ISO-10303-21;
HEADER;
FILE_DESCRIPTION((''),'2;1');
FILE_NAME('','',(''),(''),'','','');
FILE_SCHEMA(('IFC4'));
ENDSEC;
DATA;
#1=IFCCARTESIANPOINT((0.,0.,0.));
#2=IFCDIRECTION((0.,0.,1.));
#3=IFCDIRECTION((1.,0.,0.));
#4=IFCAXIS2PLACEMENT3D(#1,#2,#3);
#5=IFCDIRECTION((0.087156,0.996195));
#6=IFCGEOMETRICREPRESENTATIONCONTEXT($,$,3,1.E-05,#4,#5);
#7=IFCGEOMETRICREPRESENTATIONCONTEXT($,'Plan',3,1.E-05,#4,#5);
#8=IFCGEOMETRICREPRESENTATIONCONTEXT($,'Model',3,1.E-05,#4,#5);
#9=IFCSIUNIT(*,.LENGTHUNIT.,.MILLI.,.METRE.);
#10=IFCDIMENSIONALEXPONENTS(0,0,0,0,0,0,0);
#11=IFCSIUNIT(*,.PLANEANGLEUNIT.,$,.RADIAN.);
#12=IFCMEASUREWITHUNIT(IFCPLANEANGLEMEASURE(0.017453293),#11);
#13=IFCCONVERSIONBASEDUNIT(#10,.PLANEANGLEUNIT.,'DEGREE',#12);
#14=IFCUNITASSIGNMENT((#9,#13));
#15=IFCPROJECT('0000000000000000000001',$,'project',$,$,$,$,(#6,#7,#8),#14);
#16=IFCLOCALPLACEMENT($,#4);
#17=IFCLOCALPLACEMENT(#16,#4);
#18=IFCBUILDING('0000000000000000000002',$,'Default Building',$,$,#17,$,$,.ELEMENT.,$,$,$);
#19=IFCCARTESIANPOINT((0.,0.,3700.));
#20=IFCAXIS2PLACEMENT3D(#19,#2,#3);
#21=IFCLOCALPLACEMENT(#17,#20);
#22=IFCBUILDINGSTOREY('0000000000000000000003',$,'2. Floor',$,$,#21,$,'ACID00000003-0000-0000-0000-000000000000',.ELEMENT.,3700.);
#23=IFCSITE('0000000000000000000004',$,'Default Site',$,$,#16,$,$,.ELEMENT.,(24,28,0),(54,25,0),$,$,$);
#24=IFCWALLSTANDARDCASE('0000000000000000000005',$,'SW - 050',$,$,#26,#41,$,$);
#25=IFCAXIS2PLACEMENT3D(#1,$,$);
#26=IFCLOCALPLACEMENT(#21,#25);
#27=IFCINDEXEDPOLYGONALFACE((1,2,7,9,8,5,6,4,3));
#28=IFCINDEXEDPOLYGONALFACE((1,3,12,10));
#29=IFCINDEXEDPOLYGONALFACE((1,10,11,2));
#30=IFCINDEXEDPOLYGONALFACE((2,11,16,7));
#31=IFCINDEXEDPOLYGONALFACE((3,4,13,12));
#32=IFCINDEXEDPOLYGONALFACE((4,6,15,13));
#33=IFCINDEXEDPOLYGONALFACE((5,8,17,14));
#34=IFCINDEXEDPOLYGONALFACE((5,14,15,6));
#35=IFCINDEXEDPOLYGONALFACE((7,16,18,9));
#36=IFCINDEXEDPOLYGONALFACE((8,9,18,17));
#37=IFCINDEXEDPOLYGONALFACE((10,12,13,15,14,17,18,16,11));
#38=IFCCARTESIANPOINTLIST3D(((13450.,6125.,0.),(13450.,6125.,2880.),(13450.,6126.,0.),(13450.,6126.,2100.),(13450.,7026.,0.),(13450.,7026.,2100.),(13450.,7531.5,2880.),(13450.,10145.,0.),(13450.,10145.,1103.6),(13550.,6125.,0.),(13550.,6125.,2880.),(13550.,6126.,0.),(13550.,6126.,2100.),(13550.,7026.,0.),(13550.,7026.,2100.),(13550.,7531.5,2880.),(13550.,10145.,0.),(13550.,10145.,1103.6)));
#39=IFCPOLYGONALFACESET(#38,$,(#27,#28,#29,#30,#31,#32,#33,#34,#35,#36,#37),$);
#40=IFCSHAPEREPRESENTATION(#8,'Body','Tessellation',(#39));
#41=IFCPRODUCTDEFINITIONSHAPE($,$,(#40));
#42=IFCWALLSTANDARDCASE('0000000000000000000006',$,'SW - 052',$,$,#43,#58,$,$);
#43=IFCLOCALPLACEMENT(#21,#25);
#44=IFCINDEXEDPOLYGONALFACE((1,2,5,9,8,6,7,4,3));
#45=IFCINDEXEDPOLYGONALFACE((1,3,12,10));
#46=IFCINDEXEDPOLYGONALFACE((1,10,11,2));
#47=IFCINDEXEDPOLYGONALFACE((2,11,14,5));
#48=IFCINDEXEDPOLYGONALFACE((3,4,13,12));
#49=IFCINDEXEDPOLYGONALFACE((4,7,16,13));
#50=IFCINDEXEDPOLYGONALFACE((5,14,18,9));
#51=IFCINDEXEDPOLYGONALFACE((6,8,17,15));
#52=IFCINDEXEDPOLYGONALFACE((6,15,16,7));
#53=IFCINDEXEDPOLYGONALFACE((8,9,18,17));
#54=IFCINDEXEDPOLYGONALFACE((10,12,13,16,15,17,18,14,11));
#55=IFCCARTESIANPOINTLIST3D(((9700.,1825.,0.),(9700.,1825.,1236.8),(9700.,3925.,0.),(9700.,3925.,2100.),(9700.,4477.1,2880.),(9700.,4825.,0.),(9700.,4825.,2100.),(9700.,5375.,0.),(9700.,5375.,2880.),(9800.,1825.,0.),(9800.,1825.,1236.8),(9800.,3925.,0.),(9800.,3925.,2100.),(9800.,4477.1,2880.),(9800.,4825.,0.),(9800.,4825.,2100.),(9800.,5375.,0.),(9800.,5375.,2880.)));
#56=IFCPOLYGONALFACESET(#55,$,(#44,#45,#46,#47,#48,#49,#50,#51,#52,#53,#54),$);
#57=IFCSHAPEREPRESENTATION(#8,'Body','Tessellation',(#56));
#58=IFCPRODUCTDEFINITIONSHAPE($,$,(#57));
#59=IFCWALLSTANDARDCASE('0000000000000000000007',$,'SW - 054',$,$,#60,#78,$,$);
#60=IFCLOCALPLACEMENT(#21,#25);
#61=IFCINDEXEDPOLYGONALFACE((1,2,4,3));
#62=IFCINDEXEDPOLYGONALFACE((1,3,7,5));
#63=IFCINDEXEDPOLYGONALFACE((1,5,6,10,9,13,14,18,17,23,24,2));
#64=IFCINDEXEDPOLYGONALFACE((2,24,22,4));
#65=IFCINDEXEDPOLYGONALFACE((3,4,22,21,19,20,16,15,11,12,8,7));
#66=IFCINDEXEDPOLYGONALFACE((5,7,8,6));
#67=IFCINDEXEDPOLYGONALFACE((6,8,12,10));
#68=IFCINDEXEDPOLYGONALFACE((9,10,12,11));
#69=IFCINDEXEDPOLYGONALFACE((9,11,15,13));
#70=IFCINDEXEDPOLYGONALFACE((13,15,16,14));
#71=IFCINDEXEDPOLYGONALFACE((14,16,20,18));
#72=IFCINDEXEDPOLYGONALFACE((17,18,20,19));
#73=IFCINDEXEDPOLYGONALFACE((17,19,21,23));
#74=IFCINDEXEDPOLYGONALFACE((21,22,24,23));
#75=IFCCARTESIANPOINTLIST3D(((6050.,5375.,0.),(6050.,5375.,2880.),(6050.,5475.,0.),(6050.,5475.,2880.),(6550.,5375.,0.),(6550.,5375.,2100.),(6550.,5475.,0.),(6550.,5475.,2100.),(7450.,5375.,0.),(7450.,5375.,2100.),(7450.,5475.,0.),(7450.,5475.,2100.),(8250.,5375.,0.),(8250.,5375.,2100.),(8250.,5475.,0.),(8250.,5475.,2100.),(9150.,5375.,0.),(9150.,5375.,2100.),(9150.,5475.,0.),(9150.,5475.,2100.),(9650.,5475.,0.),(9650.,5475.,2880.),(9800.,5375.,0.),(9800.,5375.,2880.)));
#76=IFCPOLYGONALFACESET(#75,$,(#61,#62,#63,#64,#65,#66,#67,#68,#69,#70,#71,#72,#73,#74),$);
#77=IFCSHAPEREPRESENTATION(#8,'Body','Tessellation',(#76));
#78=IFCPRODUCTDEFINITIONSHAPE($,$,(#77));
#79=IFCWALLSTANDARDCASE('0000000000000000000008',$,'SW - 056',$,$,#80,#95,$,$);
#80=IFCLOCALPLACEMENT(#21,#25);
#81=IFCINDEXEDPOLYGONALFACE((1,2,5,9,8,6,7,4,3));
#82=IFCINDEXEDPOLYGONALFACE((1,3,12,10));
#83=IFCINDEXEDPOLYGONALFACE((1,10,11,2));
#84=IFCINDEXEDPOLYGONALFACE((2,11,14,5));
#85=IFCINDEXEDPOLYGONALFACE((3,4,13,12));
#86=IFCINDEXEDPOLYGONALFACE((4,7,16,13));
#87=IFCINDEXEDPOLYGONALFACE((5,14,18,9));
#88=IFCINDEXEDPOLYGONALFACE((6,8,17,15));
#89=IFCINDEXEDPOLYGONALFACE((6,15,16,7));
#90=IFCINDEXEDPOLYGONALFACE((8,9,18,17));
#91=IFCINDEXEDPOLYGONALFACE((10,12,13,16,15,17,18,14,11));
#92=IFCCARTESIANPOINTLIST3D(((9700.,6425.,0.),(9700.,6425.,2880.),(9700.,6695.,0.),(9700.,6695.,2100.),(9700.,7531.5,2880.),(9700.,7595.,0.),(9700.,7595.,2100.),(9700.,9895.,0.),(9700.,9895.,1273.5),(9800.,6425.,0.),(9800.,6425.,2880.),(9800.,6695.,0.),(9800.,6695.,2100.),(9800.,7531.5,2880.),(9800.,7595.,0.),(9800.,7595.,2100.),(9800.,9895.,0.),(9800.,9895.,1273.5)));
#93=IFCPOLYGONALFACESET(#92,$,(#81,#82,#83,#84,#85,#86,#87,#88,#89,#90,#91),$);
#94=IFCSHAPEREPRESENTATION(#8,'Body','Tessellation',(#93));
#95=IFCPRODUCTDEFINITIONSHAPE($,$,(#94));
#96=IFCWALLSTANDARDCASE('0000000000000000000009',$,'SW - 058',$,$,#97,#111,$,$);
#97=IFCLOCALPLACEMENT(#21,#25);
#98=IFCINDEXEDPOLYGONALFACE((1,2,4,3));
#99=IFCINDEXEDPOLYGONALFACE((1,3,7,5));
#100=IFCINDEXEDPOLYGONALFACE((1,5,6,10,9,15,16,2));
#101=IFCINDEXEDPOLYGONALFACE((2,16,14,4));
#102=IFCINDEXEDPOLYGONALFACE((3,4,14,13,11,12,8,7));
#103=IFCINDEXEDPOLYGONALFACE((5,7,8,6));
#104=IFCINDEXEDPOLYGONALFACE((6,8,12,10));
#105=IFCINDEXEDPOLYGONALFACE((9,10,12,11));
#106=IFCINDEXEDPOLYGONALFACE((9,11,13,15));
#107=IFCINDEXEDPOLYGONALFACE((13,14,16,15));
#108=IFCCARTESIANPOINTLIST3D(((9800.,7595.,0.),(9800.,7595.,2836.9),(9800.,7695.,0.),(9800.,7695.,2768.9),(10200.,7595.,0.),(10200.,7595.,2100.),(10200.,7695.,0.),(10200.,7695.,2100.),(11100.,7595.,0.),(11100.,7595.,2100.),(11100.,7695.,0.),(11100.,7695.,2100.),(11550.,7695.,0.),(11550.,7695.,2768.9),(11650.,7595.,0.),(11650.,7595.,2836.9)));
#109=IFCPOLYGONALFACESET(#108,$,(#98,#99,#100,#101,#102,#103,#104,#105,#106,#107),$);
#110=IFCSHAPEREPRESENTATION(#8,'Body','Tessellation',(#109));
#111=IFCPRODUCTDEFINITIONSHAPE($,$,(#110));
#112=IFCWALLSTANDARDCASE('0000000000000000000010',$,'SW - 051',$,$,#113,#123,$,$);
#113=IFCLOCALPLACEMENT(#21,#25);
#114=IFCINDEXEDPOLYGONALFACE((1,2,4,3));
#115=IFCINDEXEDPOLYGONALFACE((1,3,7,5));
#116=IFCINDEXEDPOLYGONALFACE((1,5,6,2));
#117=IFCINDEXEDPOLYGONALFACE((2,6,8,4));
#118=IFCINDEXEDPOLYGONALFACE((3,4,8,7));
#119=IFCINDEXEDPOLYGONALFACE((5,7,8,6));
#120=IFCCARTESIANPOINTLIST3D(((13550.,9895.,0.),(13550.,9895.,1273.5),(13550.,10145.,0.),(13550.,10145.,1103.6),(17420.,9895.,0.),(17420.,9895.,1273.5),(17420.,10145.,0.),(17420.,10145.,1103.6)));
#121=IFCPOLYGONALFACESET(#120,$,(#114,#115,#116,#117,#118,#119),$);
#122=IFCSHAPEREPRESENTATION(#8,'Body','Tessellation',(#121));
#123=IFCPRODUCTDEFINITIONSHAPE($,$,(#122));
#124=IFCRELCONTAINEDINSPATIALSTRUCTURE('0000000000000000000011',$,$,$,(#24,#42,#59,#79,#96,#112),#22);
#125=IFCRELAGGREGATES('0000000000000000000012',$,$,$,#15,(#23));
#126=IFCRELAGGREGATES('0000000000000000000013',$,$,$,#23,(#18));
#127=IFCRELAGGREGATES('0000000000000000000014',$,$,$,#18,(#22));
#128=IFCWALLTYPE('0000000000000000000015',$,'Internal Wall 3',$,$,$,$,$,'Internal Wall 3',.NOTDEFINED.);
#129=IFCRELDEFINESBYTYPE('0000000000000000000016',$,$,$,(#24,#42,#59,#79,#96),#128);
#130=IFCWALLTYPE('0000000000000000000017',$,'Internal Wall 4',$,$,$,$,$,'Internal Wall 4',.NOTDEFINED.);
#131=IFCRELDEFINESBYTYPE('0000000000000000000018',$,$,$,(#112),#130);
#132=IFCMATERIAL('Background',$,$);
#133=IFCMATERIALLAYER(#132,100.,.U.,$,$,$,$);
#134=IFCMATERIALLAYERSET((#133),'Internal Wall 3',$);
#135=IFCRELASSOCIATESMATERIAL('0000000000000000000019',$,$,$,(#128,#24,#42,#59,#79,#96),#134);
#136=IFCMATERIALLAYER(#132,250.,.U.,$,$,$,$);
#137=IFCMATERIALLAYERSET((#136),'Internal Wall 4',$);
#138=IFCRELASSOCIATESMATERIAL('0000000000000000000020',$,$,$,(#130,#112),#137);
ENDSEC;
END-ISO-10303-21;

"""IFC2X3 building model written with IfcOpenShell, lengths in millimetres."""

from ifc_helpers import new_model, entity, si_unit, converted_unit, direction, frame, frame_2d, origin_with_axes, place, context, project, spatial, polyline, rectangle, outline, extrude, clip, halfspace, material, layer, layer_set, layer_usage, type_object, element, save


model = new_model("IFC2X3")

# Units and contexts
context_of_model = context(None, 3, precision=1e-05, world=origin_with_axes(), true_north=direction((0.087156, 0.996195)))
plan_context = context("Plan", 3, precision=1e-05, world=origin_with_axes(), true_north=direction((0.087156, 0.996195)))
model_context = context("Model", 3, precision=1e-05, world=origin_with_axes(), true_north=direction((0.087156, 0.996195)))
ifc_project = project(units=[si_unit("LENGTHUNIT", "METRE", prefix="MILLI"), converted_unit("PLANEANGLEUNIT", "DEGREE", entity("IfcPlaneAngleMeasure", 0.017453293), si_unit("PLANEANGLEUNIT", "RADIAN"), dimensions=[0, 0, 0, 0, 0, 0, 0])], contexts=[context_of_model, plan_context, model_context])

# Site, building, storey
site_placement = place(None, origin_with_axes())
site = spatial("IfcSite", under=ifc_project, at=site_placement, Name="Default Site", CompositionType="ELEMENT", RefLatitude=(24, 28, 0), RefLongitude=(54, 25, 0))
building_placement = place(site_placement, origin_with_axes())
building = spatial("IfcBuilding", under=site, at=building_placement, Name="Default Building", CompositionType="ELEMENT")
storey_placement = place(building_placement, frame((0.0, 0.0, 3700.0), z_axis=(0.0, 0.0, 1.0), x_axis=(1.0, 0.0, 0.0)))
storey = spatial("IfcBuildingStorey", under=building, at=storey_placement, Name="2. Floor", LongName="ACID00000003-0000-0000-0000-000000000000", CompositionType="ELEMENT", Elevation=3700.0)

# Shared definitions
ifc_material = material(Name="Background")

# Shared definitions
ifc_layer_1 = layer(ifc_material, 100.0, ventilated="UNKNOWN")
ifc_layer_set_1 = layer_set([ifc_layer_1], Name="Internal Wall 3")
wall_type_1 = type_object("IfcWallType", Name="Internal Wall 3", ElementType="Internal Wall 3", PredefinedType="NOTDEFINED", material=ifc_layer_set_1)

# Walls, openings
ifc_layer_usage_1 = layer_usage(ifc_layer_set_1, "AXIS2", "POSITIVE", 0.0)
wall_1_placement = place(storey_placement, frame((13450.0, 10145.0, 0.0), z_axis=(0.0, 0.0, 1.0), x_axis=(0.0, -1.0, 0.0)))
wall_1 = element("IfcWallStandardCase", 1, at=wall_1_placement, inside=storey, type_object=wall_type_1, material=ifc_layer_usage_1, Name="SW - 050", context=model_context, shape_type="Clipping", body=[
    clip(clip(extrude(outline(polyline([(0.0, 0.0), (4020.0, 0.0), (4020.0, 100.0), (0.0, 100.0), (0.0, 0.0)])), origin_with_axes(), (0.0, 0.0, 1.0), 2880.0), halfspace(frame((-513.1, 0.0, 754.9), z_axis=(-0.562142, 0.0, 0.827041), x_axis=(0.0, 1.0, 0.0)), False)), halfspace(frame((-513.1, 0.0, 754.9), z_axis=(-0.562142, 0.0, 0.827041), x_axis=(0.0, 1.0, 0.0)), False)),
])
opening_1_placement = place(wall_1_placement, frame((3569.0, 0.0, 0.0), z_axis=(0.0, 0.0, 1.0), x_axis=(1.0, 0.0, 0.0)))
element("IfcOpeningElement", 2, at=opening_1_placement, cuts=wall_1, ObjectType="Opening", context=model_context, shape_type="SweptSolid", body=[
    extrude(rectangle(XDim=900.0, YDim=2100.0, at=frame_2d((0.0, 1050.0), x_axis=(-1.0, 0.0))), frame((0.0, 0.0, 0.0), z_axis=(0.0, 1.0, 0.0), x_axis=(-1.0, 0.0, 0.0)), (0.0, 0.0, 1.0), 100.0),
])
ifc_layer_usage_2 = layer_usage(ifc_layer_set_1, "AXIS2", "NEGATIVE", 0.0)
wall_2_placement = place(storey_placement, frame((9700.0, 1825.0, 0.0), z_axis=(0.0, 0.0, 1.0), x_axis=(0.0, 1.0, 0.0)))
wall_2 = element("IfcWallStandardCase", 3, at=wall_2_placement, inside=storey, type_object=wall_type_1, material=ifc_layer_usage_2, Name="SW - 052", context=model_context, shape_type="Clipping", body=[
    clip(extrude(outline(polyline([(0.0, -100.0), (3550.0, -100.0), (3550.0, 0.0), (0.0, 0.0), (0.0, -100.0)])), origin_with_axes(), (0.0, 0.0, 1.0), 2880.0), halfspace(frame((-553.7, 0.0, 893.8), z_axis=(-0.526673, 0.0, 0.850068), x_axis=(0.0, 1.0, 0.0)), False)),
])
opening_2_placement = place(wall_2_placement, frame((2550.0, -100.0, 0.0), z_axis=(0.0, 0.0, 1.0), x_axis=(1.0, 0.0, 0.0)))
element("IfcOpeningElement", 4, at=opening_2_placement, cuts=wall_2, ObjectType="Opening", context=model_context, shape_type="SweptSolid", body=[
    extrude(rectangle(XDim=900.0, YDim=2100.0, at=frame_2d((0.0, 1050.0), x_axis=(-1.0, 0.0))), frame((0.0, 0.0, 0.0), z_axis=(0.0, 1.0, 0.0), x_axis=(-1.0, 0.0, 0.0)), (0.0, 0.0, 1.0), 100.0),
])

# Wall, openings
ifc_layer_usage_3 = layer_usage(ifc_layer_set_1, "AXIS2", "NEGATIVE", 0.0)
wall_3_placement = place(storey_placement, frame((9800.0, 5375.0, 0.0), z_axis=(0.0, 0.0, 1.0), x_axis=(-1.0, 0.0, 0.0)))
wall_3 = element("IfcWallStandardCase", 5, at=wall_3_placement, inside=storey, type_object=wall_type_1, material=ifc_layer_usage_3, Name="SW - 054", context=model_context, shape_type="SweptSolid", body=[
    extrude(outline(polyline([(150.0, -100.0), (3750.0, -100.0), (3750.0, 0.0), (0.0, 0.0), (150.0, -100.0)])), origin_with_axes(), (0.0, 0.0, 1.0), 2880.0),
])
opening_3_placement = place(wall_3_placement, frame((1100.0, -100.0, 0.0), z_axis=(0.0, 0.0, 1.0), x_axis=(1.0, 0.0, 0.0)))
element("IfcOpeningElement", 6, at=opening_3_placement, cuts=wall_3, ObjectType="Opening", context=model_context, shape_type="SweptSolid", body=[
    extrude(rectangle(XDim=900.0, YDim=2100.0, at=frame_2d((0.0, 1050.0), x_axis=(-1.0, 0.0))), frame((0.0, 0.0, 0.0), z_axis=(0.0, 1.0, 0.0), x_axis=(-1.0, 0.0, 0.0)), (0.0, 0.0, 1.0), 100.0),
])
opening_4_placement = place(wall_3_placement, frame((2800.0, -100.0, 0.0), z_axis=(0.0, 0.0, 1.0), x_axis=(1.0, 0.0, 0.0)))
element("IfcOpeningElement", 7, at=opening_4_placement, cuts=wall_3, ObjectType="Opening", context=model_context, shape_type="SweptSolid", body=[
    extrude(rectangle(XDim=900.0, YDim=2100.0, at=frame_2d((0.0, 1050.0), x_axis=(-1.0, 0.0))), frame((0.0, 0.0, 0.0), z_axis=(0.0, 1.0, 0.0), x_axis=(-1.0, 0.0, 0.0)), (0.0, 0.0, 1.0), 100.0),
])

# Wall, opening
ifc_layer_usage_4 = layer_usage(ifc_layer_set_1, "AXIS2", "POSITIVE", 0.0)
wall_4_placement = place(storey_placement, frame((9800.0, 6425.0, 0.0), z_axis=(0.0, 0.0, 1.0), x_axis=(0.0, 1.0, 0.0)))
wall_4 = element("IfcWallStandardCase", 8, at=wall_4_placement, inside=storey, type_object=wall_type_1, material=ifc_layer_usage_4, Name="SW - 056", context=model_context, shape_type="Clipping", body=[
    clip(clip(extrude(outline(polyline([(0.0, 0.0), (3470.0, 0.0), (3470.0, 100.0), (0.0, 100.0), (0.0, 0.0)])), origin_with_axes(), (0.0, 0.0, 1.0), 2880.0), halfspace(frame((1688.6, 0.0, 2484.3), z_axis=(0.562142, 0.0, 0.827041), x_axis=(0.0, 1.0, 0.0)), False)), halfspace(frame((1688.6, 0.0, 2484.3), z_axis=(0.562142, 0.0, 0.827041), x_axis=(0.0, 1.0, 0.0)), False)),
])
opening_5_placement = place(wall_4_placement, frame((720.0, 0.0, 0.0), z_axis=(0.0, 0.0, 1.0), x_axis=(1.0, 0.0, 0.0)))
element("IfcOpeningElement", 9, at=opening_5_placement, cuts=wall_4, ObjectType="Opening", context=model_context, shape_type="SweptSolid", body=[
    extrude(rectangle(XDim=900.0, YDim=2100.0, at=frame_2d((0.0, 1050.0), x_axis=(-1.0, 0.0))), frame((0.0, 0.0, 0.0), z_axis=(0.0, 1.0, 0.0), x_axis=(-1.0, 0.0, 0.0)), (0.0, 0.0, 1.0), 100.0),
])

# Wall, opening
ifc_layer_usage_5 = layer_usage(ifc_layer_set_1, "AXIS2", "NEGATIVE", 0.0)
wall_5_placement = place(storey_placement, frame((11550.0, 7595.0, 0.0), z_axis=(0.0, 0.0, 1.0), x_axis=(-1.0, 0.0, 0.0)))
wall_5 = element("IfcWallStandardCase", 10, at=wall_5_placement, inside=storey, type_object=wall_type_1, material=ifc_layer_usage_5, Name="SW - 058", context=model_context, shape_type="Clipping", body=[
    clip(extrude(outline(polyline([(0.0, -100.0), (1750.0, -100.0), (1750.0, 0.0), (-100.0, 0.0), (0.0, -100.0)])), origin_with_axes(), (0.0, 0.0, 1.0), 2836.9), halfspace(frame((0.0, -1318.9, 1940.4), z_axis=(0.0, -0.562142, 0.827041), x_axis=(0.0, 0.827041, 0.562142)), False)),
])
opening_6_placement = place(wall_5_placement, frame((900.0, -100.0, 0.0), z_axis=(0.0, 0.0, 1.0), x_axis=(1.0, 0.0, 0.0)))
element("IfcOpeningElement", 11, at=opening_6_placement, cuts=wall_5, ObjectType="Opening", context=model_context, shape_type="SweptSolid", body=[
    extrude(rectangle(XDim=900.0, YDim=2100.0, at=frame_2d((0.0, 1050.0), x_axis=(-1.0, 0.0))), frame((0.0, 0.0, 0.0), z_axis=(0.0, 1.0, 0.0), x_axis=(-1.0, 0.0, 0.0)), (0.0, 0.0, 1.0), 100.0),
])

# Wall
ifc_layer_2 = layer(ifc_material, 250.0, ventilated="UNKNOWN")
ifc_layer_set_2 = layer_set([ifc_layer_2], Name="Internal Wall 4")
ifc_layer_usage_6 = layer_usage(ifc_layer_set_2, "AXIS2", "POSITIVE", 0.0)
wall_type_2 = type_object("IfcWallType", Name="Internal Wall 4", ElementType="Internal Wall 4", PredefinedType="NOTDEFINED", material=ifc_layer_set_2)
wall_6_placement = place(storey_placement, frame((13550.0, 9895.0, 0.0), z_axis=(0.0, 0.0, 1.0), x_axis=(1.0, 0.0, 0.0)))
element("IfcWallStandardCase", 12, at=wall_6_placement, inside=storey, type_object=wall_type_2, material=ifc_layer_usage_6, Name="SW - 051", context=model_context, shape_type="Clipping", body=[
    clip(clip(extrude(outline(polyline([(0.0, 0.0), (3870.0, 0.0), (3870.0, 250.0), (0.0, 250.0), (0.0, 0.0)])), origin_with_axes(), (0.0, 0.0, 1.0), 1273.5), halfspace(frame((0.0, 592.1, 871.1), z_axis=(0.0, 0.562142, 0.827041), x_axis=(0.0, 0.827041, -0.562142)), False)), halfspace(frame((0.0, 592.1, 871.1), z_axis=(0.0, 0.562142, 0.827041), x_axis=(0.0, 0.827041, -0.562142)), False)),
])

save(model, "model.ifc")
